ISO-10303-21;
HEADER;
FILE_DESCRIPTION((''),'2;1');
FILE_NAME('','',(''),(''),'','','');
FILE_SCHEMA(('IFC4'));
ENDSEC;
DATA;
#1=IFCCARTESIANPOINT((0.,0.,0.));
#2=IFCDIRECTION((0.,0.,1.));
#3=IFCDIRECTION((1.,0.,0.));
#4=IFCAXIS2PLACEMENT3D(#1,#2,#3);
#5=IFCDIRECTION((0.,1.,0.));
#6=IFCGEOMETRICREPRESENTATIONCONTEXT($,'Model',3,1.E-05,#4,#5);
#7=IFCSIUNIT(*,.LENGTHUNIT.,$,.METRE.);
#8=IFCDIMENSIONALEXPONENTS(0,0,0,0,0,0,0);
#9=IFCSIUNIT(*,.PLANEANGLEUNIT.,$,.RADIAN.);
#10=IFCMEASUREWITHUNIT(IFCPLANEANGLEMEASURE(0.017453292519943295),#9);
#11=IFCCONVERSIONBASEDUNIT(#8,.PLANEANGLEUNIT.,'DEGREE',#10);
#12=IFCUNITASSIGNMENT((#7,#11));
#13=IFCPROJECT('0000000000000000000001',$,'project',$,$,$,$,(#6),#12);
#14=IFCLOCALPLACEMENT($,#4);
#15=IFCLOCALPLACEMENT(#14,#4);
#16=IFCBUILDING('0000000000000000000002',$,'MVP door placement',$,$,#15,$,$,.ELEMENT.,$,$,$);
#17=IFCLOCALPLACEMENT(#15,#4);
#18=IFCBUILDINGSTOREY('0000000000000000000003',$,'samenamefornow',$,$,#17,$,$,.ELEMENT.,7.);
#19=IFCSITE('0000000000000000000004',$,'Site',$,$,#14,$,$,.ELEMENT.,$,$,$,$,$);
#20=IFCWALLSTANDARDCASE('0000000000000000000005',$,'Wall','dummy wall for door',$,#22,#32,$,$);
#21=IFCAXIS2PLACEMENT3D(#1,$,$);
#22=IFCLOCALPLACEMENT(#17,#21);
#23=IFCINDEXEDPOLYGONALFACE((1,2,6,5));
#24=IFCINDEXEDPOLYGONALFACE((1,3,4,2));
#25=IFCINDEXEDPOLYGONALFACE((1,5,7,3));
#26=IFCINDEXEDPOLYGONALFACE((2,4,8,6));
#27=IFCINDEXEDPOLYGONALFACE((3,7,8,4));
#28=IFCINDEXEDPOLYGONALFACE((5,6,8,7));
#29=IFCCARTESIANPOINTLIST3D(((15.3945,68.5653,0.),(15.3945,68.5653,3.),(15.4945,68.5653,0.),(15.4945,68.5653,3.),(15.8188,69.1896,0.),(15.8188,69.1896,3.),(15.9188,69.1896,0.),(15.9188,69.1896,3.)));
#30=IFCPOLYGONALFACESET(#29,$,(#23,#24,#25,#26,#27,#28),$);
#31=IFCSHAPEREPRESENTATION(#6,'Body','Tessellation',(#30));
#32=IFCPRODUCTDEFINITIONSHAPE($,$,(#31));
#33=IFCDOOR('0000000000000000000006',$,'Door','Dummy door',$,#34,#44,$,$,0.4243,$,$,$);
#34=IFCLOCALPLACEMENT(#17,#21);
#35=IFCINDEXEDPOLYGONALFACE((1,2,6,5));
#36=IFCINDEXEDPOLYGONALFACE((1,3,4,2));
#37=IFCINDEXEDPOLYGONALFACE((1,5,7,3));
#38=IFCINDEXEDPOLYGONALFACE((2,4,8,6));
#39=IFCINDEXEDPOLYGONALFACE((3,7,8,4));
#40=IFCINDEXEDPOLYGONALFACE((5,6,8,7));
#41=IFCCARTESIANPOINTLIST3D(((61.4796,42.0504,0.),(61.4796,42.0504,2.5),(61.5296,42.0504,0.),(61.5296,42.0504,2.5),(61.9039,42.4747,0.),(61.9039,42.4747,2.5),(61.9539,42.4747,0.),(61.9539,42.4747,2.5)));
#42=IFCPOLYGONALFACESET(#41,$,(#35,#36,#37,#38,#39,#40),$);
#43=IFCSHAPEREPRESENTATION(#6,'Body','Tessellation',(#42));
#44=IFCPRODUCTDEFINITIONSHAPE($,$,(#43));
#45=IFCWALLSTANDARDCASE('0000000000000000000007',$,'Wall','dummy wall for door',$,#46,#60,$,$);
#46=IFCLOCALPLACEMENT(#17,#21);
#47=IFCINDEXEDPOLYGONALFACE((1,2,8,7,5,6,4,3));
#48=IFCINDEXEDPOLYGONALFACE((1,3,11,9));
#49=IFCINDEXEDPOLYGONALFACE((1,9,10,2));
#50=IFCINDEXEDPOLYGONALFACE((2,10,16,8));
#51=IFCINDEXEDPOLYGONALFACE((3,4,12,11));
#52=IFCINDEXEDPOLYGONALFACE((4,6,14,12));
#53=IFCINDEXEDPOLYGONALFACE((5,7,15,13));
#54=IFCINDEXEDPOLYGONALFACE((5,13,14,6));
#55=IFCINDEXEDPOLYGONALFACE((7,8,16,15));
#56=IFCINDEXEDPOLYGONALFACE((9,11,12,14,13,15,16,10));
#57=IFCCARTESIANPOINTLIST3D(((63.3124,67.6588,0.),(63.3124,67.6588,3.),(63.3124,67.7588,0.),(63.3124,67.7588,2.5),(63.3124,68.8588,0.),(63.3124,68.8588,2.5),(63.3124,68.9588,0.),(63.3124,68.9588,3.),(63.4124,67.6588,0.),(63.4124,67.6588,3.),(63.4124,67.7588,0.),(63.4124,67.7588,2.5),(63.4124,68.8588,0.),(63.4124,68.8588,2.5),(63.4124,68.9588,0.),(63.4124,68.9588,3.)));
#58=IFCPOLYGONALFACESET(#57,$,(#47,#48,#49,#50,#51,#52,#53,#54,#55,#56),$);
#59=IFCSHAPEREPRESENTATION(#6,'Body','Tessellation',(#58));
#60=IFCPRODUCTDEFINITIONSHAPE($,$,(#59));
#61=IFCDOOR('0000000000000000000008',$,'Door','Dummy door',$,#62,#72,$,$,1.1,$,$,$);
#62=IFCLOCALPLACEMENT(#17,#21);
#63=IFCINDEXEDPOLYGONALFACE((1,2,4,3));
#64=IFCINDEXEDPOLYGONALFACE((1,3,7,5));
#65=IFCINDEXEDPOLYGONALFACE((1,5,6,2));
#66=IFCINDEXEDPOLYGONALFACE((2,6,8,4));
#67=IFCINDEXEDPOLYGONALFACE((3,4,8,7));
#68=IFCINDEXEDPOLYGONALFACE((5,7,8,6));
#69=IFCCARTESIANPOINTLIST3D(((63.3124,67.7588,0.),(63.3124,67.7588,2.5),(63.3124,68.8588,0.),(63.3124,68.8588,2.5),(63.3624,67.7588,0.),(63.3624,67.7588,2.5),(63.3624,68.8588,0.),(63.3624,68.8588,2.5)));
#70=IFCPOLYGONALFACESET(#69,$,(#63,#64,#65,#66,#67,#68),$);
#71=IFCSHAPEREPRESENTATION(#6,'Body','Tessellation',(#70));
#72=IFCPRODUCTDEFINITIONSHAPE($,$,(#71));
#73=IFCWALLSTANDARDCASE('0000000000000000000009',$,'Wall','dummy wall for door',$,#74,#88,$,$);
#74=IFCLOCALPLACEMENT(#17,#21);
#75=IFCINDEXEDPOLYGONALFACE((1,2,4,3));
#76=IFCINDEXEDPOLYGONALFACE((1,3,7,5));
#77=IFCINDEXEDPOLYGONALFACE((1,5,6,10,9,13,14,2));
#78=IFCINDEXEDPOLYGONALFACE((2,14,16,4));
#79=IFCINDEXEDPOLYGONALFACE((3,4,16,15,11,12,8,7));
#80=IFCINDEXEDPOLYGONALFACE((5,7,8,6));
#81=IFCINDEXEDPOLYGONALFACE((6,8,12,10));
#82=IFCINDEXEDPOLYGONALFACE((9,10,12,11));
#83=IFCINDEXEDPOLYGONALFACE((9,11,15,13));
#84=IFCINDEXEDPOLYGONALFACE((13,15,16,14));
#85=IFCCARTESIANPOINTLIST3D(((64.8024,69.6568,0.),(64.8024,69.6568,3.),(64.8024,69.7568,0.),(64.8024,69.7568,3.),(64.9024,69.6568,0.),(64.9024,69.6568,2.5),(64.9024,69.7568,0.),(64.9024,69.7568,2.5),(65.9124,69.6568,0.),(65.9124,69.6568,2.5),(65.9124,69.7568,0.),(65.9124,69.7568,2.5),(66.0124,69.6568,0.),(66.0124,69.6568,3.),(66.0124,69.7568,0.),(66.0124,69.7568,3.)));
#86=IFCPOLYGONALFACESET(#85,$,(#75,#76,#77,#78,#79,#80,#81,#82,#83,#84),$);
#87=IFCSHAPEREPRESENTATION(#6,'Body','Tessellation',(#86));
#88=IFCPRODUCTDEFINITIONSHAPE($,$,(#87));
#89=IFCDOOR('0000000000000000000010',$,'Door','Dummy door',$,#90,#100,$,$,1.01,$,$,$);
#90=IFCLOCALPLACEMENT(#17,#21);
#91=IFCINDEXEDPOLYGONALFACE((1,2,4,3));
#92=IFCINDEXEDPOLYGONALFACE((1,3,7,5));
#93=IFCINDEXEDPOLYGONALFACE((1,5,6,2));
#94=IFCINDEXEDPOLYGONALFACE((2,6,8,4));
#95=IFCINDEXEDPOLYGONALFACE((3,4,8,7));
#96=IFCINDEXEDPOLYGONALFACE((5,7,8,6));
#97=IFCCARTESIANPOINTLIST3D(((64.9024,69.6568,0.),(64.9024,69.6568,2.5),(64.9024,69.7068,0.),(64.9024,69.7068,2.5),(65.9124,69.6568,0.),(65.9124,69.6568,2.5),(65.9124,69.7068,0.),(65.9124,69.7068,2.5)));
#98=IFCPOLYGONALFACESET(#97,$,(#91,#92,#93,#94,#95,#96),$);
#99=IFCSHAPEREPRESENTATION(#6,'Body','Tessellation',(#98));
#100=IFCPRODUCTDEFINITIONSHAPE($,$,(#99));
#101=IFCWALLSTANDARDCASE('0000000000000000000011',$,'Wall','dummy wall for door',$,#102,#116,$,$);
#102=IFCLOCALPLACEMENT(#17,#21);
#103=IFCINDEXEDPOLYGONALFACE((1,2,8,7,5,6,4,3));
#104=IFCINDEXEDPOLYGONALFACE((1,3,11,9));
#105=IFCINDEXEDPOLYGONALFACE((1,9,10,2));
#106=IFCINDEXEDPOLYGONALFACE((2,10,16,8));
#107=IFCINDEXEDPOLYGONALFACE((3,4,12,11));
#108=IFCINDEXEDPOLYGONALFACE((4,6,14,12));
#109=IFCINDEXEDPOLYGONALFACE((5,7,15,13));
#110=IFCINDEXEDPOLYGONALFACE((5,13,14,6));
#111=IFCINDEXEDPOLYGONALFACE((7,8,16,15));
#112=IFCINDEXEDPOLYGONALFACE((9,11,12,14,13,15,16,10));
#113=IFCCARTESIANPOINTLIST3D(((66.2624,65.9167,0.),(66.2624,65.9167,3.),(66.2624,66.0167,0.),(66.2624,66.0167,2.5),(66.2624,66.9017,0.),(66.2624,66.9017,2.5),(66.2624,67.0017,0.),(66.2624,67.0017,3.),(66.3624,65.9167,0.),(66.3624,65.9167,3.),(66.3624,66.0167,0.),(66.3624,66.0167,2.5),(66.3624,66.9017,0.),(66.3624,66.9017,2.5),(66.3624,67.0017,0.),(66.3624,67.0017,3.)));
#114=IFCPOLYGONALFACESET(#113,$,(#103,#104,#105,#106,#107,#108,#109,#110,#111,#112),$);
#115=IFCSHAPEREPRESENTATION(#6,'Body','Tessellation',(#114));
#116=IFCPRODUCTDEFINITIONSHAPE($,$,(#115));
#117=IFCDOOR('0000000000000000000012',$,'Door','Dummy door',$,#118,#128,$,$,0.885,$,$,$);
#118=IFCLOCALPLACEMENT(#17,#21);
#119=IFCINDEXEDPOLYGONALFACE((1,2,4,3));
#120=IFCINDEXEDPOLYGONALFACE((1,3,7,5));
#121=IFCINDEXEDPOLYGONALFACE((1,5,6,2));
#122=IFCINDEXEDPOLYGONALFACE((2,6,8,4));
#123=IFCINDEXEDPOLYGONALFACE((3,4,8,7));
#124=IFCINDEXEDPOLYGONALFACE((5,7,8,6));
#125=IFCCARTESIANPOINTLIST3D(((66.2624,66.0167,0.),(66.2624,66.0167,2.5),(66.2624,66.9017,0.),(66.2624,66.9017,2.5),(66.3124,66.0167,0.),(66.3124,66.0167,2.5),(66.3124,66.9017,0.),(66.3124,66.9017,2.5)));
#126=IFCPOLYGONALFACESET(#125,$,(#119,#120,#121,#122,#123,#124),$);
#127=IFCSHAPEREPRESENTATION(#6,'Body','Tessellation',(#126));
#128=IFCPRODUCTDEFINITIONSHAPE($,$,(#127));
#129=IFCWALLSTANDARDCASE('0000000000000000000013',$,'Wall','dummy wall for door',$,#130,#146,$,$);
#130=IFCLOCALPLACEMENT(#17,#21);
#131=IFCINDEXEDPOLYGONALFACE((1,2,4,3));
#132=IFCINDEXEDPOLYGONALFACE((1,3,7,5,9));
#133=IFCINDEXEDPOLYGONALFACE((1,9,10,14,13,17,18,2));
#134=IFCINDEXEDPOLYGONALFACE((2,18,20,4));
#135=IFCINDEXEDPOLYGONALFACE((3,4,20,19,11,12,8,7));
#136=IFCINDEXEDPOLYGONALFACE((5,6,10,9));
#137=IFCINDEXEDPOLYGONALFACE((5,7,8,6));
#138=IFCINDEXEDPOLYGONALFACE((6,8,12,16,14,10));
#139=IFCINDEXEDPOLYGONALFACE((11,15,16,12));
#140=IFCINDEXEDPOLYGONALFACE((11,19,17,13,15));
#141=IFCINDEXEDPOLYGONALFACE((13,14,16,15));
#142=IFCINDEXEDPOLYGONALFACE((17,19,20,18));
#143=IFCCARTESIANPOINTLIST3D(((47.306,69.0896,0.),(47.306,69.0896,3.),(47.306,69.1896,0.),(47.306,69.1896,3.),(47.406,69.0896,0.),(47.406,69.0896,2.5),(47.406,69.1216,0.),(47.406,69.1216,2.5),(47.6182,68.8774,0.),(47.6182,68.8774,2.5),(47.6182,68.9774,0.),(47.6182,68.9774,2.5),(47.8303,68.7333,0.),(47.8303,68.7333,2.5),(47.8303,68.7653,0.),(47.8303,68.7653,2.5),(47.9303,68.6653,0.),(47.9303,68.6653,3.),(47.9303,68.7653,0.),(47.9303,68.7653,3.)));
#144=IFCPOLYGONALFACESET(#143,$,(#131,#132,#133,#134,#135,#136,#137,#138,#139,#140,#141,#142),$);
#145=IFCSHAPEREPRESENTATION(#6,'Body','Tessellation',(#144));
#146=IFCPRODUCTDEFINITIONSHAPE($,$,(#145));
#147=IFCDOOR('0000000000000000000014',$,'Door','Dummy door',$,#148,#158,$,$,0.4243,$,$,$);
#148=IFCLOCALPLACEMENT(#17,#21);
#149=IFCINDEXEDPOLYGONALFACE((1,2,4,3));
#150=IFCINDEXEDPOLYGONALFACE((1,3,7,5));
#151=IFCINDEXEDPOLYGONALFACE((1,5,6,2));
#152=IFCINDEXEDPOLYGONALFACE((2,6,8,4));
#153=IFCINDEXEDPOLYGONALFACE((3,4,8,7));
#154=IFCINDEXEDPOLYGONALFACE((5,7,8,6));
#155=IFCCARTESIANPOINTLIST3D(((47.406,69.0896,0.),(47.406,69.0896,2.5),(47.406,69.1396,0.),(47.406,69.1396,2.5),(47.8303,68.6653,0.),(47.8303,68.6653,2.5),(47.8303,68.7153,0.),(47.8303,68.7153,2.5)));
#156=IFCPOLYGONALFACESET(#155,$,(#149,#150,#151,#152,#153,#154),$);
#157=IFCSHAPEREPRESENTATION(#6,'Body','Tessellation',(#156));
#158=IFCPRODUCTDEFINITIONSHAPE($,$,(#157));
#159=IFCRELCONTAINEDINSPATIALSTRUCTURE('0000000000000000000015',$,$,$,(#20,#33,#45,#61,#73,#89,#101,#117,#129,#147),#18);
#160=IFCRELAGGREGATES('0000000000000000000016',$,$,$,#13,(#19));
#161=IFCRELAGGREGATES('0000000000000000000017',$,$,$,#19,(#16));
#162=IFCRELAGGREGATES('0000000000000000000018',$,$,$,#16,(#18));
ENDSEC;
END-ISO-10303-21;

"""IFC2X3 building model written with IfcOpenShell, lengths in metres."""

from ifc_helpers import new_model, entity, si_unit, converted_unit, direction, origin_with_axes, place, context, project, spatial, polyline, outline, extrude, element, fill, save


model = new_model("IFC2X3")

# Units and contexts
model_context = context("Model", 3, precision=1e-05, world=origin_with_axes(), true_north=direction((0.0, 1.0, 0.0)))
ifc_project = project(units=[si_unit("LENGTHUNIT", "METRE"), converted_unit("PLANEANGLEUNIT", "DEGREE", entity("IfcPlaneAngleMeasure", 0.017453292519943295), si_unit("PLANEANGLEUNIT", "RADIAN"), dimensions=[0, 0, 0, 0, 0, 0, 0])], contexts=[model_context])

# Site, building, storey
site_placement = place(None, origin_with_axes())
site = spatial("IfcSite", under=ifc_project, at=site_placement, Name="Site", CompositionType="ELEMENT")
building_placement = place(site_placement, origin_with_axes())
building = spatial("IfcBuilding", under=site, at=building_placement, Name="MVP door placement", CompositionType="ELEMENT")
storey_placement = place(building_placement, origin_with_axes())
storey = spatial("IfcBuildingStorey", under=building, at=storey_placement, Name="samenamefornow", CompositionType="ELEMENT", Elevation=7.0)

# Walls, openings, doors
wall_1_placement = place(storey_placement, origin_with_axes())
wall_1 = element("IfcWallStandardCase", 1, at=wall_1_placement, inside=storey, Name="Wall", Description="dummy wall for door", context=model_context, shape_type="SweptSolid", body=[
    extrude(outline(polyline([(15.8188, 69.1896, 0.0), (15.3945, 68.5653, 0.0), (15.4945, 68.5653, 0.0), (15.9188, 69.1896, 0.0), (15.8188, 69.1896, 0.0)])), origin_with_axes(), (0.0, 0.0, 1.0), 3.0),
])
opening_1_placement = place(wall_1_placement, origin_with_axes())
opening_1 = element("IfcOpeningElement", 2, at=opening_1_placement, cuts=wall_1, context=model_context, shape_type="SweptSolid", body=[
    extrude(outline(polyline([(61.4796, 42.0504, 0.0), (61.9039, 42.4747, 0.0), (62.0039, 42.4747, 0.0), (61.5796, 42.0504, 0.0), (61.4796, 42.0504, 0.0)])), origin_with_axes(), (0.0, 0.0, 1.0), 2.5),
])
door_1_placement = place(opening_1_placement, origin_with_axes())
door_1 = element("IfcDoor", 3, at=door_1_placement, inside=storey, Name="Door", Description="Dummy door", OverallWidth=0.4243, context=model_context, shape_type="SweptSolid", body=[
    extrude(outline(polyline([(61.4796, 42.0504, 0.0), (61.9039, 42.4747, 0.0), (61.9539, 42.4747, 0.0), (61.5296, 42.0504, 0.0), (61.4796, 42.0504, 0.0)])), origin_with_axes(), (0.0, 0.0, 1.0), 2.5),
])
fill(opening_1, door_1)
wall_2_placement = place(storey_placement, origin_with_axes())
wall_2 = element("IfcWallStandardCase", 4, at=wall_2_placement, inside=storey, Name="Wall", Description="dummy wall for door", context=model_context, shape_type="SweptSolid", body=[
    extrude(outline(polyline([(63.3124, 67.6588, 0.0), (63.3124, 68.9588, 0.0), (63.4124, 68.9588, 0.0), (63.4124, 67.6588, 0.0), (63.3124, 67.6588, 0.0)])), origin_with_axes(), (0.0, 0.0, 1.0), 3.0),
])
opening_2_placement = place(wall_2_placement, origin_with_axes())
opening_2 = element("IfcOpeningElement", 5, at=opening_2_placement, cuts=wall_2, context=model_context, shape_type="SweptSolid", body=[
    extrude(outline(polyline([(63.3124, 67.7588, 0.0), (63.3124, 68.8588, 0.0), (63.4124, 68.8588, 0.0), (63.4124, 67.7588, 0.0), (63.3124, 67.7588, 0.0)])), origin_with_axes(), (0.0, 0.0, 1.0), 2.5),
])
door_2_placement = place(opening_2_placement, origin_with_axes())
door_2 = element("IfcDoor", 6, at=door_2_placement, inside=storey, Name="Door", Description="Dummy door", OverallWidth=1.1, context=model_context, shape_type="SweptSolid", body=[
    extrude(outline(polyline([(63.3124, 67.7588, 0.0), (63.3124, 68.8588, 0.0), (63.3624, 68.8588, 0.0), (63.3624, 67.7588, 0.0), (63.3124, 67.7588, 0.0)])), origin_with_axes(), (0.0, 0.0, 1.0), 2.5),
])
fill(opening_2, door_2)
wall_3_placement = place(storey_placement, origin_with_axes())
wall_3 = element("IfcWallStandardCase", 7, at=wall_3_placement, inside=storey, Name="Wall", Description="dummy wall for door", context=model_context, shape_type="SweptSolid", body=[
    extrude(outline(polyline([(66.0124, 69.6568, 0.0), (64.8024, 69.6568, 0.0), (64.8024, 69.7568, 0.0), (66.0124, 69.7568, 0.0), (66.0124, 69.6568, 0.0)])), origin_with_axes(), (0.0, 0.0, 1.0), 3.0),
])
opening_3_placement = place(wall_3_placement, origin_with_axes())
opening_3 = element("IfcOpeningElement", 8, at=opening_3_placement, cuts=wall_3, context=model_context, shape_type="SweptSolid", body=[
    extrude(outline(polyline([(65.9124, 69.6568, 0.0), (64.9024, 69.6568, 0.0), (64.9024, 69.7568, 0.0), (65.9124, 69.7568, 0.0), (65.9124, 69.6568, 0.0)])), origin_with_axes(), (0.0, 0.0, 1.0), 2.5),
])
door_3_placement = place(opening_3_placement, origin_with_axes())
door_3 = element("IfcDoor", 9, at=door_3_placement, inside=storey, Name="Door", Description="Dummy door", OverallWidth=1.01, context=model_context, shape_type="SweptSolid", body=[
    extrude(outline(polyline([(65.9124, 69.6568, 0.0), (64.9024, 69.6568, 0.0), (64.9024, 69.7068, 0.0), (65.9124, 69.7068, 0.0), (65.9124, 69.6568, 0.0)])), origin_with_axes(), (0.0, 0.0, 1.0), 2.5),
])
fill(opening_3, door_3)
wall_4_placement = place(storey_placement, origin_with_axes())
wall_4 = element("IfcWallStandardCase", 10, at=wall_4_placement, inside=storey, Name="Wall", Description="dummy wall for door", context=model_context, shape_type="SweptSolid", body=[
    extrude(outline(polyline([(66.2624, 67.0017, 0.0), (66.2624, 65.9167, 0.0), (66.3624, 65.9167, 0.0), (66.3624, 67.0017, 0.0), (66.2624, 67.0017, 0.0)])), origin_with_axes(), (0.0, 0.0, 1.0), 3.0),
])
opening_4_placement = place(wall_4_placement, origin_with_axes())
opening_4 = element("IfcOpeningElement", 11, at=opening_4_placement, cuts=wall_4, context=model_context, shape_type="SweptSolid", body=[
    extrude(outline(polyline([(66.2624, 66.9017, 0.0), (66.2624, 66.0167, 0.0), (66.3624, 66.0167, 0.0), (66.3624, 66.9017, 0.0), (66.2624, 66.9017, 0.0)])), origin_with_axes(), (0.0, 0.0, 1.0), 2.5),
])
door_4_placement = place(opening_4_placement, origin_with_axes())
door_4 = element("IfcDoor", 12, at=door_4_placement, inside=storey, Name="Door", Description="Dummy door", OverallWidth=0.885, context=model_context, shape_type="SweptSolid", body=[
    extrude(outline(polyline([(66.2624, 66.9017, 0.0), (66.2624, 66.0167, 0.0), (66.3124, 66.0167, 0.0), (66.3124, 66.9017, 0.0), (66.2624, 66.9017, 0.0)])), origin_with_axes(), (0.0, 0.0, 1.0), 2.5),
])
fill(opening_4, door_4)
wall_5_placement = place(storey_placement, origin_with_axes())
wall_5 = element("IfcWallStandardCase", 13, at=wall_5_placement, inside=storey, Name="Wall", Description="dummy wall for door", context=model_context, shape_type="SweptSolid", body=[
    extrude(outline(polyline([(47.306, 69.0896, 0.0), (47.9303, 68.6653, 0.0), (47.9303, 68.7653, 0.0), (47.306, 69.1896, 0.0), (47.306, 69.0896, 0.0)])), origin_with_axes(), (0.0, 0.0, 1.0), 3.0),
])
opening_5_placement = place(wall_5_placement, origin_with_axes())
opening_5 = element("IfcOpeningElement", 14, at=opening_5_placement, cuts=wall_5, context=model_context, shape_type="SweptSolid", body=[
    extrude(outline(polyline([(47.406, 69.0896, 0.0), (47.8303, 68.6653, 0.0), (47.8303, 68.7653, 0.0), (47.406, 69.1896, 0.0), (47.406, 69.0896, 0.0)])), origin_with_axes(), (0.0, 0.0, 1.0), 2.5),
])
door_5_placement = place(opening_5_placement, origin_with_axes())
door_5 = element("IfcDoor", 15, at=door_5_placement, inside=storey, Name="Door", Description="Dummy door", OverallWidth=0.4243, context=model_context, shape_type="SweptSolid", body=[
    extrude(outline(polyline([(47.406, 69.0896, 0.0), (47.8303, 68.6653, 0.0), (47.8303, 68.7153, 0.0), (47.406, 69.1396, 0.0), (47.406, 69.0896, 0.0)])), origin_with_axes(), (0.0, 0.0, 1.0), 2.5),
])
fill(opening_5, door_5)

save(model, "model.ifc")
